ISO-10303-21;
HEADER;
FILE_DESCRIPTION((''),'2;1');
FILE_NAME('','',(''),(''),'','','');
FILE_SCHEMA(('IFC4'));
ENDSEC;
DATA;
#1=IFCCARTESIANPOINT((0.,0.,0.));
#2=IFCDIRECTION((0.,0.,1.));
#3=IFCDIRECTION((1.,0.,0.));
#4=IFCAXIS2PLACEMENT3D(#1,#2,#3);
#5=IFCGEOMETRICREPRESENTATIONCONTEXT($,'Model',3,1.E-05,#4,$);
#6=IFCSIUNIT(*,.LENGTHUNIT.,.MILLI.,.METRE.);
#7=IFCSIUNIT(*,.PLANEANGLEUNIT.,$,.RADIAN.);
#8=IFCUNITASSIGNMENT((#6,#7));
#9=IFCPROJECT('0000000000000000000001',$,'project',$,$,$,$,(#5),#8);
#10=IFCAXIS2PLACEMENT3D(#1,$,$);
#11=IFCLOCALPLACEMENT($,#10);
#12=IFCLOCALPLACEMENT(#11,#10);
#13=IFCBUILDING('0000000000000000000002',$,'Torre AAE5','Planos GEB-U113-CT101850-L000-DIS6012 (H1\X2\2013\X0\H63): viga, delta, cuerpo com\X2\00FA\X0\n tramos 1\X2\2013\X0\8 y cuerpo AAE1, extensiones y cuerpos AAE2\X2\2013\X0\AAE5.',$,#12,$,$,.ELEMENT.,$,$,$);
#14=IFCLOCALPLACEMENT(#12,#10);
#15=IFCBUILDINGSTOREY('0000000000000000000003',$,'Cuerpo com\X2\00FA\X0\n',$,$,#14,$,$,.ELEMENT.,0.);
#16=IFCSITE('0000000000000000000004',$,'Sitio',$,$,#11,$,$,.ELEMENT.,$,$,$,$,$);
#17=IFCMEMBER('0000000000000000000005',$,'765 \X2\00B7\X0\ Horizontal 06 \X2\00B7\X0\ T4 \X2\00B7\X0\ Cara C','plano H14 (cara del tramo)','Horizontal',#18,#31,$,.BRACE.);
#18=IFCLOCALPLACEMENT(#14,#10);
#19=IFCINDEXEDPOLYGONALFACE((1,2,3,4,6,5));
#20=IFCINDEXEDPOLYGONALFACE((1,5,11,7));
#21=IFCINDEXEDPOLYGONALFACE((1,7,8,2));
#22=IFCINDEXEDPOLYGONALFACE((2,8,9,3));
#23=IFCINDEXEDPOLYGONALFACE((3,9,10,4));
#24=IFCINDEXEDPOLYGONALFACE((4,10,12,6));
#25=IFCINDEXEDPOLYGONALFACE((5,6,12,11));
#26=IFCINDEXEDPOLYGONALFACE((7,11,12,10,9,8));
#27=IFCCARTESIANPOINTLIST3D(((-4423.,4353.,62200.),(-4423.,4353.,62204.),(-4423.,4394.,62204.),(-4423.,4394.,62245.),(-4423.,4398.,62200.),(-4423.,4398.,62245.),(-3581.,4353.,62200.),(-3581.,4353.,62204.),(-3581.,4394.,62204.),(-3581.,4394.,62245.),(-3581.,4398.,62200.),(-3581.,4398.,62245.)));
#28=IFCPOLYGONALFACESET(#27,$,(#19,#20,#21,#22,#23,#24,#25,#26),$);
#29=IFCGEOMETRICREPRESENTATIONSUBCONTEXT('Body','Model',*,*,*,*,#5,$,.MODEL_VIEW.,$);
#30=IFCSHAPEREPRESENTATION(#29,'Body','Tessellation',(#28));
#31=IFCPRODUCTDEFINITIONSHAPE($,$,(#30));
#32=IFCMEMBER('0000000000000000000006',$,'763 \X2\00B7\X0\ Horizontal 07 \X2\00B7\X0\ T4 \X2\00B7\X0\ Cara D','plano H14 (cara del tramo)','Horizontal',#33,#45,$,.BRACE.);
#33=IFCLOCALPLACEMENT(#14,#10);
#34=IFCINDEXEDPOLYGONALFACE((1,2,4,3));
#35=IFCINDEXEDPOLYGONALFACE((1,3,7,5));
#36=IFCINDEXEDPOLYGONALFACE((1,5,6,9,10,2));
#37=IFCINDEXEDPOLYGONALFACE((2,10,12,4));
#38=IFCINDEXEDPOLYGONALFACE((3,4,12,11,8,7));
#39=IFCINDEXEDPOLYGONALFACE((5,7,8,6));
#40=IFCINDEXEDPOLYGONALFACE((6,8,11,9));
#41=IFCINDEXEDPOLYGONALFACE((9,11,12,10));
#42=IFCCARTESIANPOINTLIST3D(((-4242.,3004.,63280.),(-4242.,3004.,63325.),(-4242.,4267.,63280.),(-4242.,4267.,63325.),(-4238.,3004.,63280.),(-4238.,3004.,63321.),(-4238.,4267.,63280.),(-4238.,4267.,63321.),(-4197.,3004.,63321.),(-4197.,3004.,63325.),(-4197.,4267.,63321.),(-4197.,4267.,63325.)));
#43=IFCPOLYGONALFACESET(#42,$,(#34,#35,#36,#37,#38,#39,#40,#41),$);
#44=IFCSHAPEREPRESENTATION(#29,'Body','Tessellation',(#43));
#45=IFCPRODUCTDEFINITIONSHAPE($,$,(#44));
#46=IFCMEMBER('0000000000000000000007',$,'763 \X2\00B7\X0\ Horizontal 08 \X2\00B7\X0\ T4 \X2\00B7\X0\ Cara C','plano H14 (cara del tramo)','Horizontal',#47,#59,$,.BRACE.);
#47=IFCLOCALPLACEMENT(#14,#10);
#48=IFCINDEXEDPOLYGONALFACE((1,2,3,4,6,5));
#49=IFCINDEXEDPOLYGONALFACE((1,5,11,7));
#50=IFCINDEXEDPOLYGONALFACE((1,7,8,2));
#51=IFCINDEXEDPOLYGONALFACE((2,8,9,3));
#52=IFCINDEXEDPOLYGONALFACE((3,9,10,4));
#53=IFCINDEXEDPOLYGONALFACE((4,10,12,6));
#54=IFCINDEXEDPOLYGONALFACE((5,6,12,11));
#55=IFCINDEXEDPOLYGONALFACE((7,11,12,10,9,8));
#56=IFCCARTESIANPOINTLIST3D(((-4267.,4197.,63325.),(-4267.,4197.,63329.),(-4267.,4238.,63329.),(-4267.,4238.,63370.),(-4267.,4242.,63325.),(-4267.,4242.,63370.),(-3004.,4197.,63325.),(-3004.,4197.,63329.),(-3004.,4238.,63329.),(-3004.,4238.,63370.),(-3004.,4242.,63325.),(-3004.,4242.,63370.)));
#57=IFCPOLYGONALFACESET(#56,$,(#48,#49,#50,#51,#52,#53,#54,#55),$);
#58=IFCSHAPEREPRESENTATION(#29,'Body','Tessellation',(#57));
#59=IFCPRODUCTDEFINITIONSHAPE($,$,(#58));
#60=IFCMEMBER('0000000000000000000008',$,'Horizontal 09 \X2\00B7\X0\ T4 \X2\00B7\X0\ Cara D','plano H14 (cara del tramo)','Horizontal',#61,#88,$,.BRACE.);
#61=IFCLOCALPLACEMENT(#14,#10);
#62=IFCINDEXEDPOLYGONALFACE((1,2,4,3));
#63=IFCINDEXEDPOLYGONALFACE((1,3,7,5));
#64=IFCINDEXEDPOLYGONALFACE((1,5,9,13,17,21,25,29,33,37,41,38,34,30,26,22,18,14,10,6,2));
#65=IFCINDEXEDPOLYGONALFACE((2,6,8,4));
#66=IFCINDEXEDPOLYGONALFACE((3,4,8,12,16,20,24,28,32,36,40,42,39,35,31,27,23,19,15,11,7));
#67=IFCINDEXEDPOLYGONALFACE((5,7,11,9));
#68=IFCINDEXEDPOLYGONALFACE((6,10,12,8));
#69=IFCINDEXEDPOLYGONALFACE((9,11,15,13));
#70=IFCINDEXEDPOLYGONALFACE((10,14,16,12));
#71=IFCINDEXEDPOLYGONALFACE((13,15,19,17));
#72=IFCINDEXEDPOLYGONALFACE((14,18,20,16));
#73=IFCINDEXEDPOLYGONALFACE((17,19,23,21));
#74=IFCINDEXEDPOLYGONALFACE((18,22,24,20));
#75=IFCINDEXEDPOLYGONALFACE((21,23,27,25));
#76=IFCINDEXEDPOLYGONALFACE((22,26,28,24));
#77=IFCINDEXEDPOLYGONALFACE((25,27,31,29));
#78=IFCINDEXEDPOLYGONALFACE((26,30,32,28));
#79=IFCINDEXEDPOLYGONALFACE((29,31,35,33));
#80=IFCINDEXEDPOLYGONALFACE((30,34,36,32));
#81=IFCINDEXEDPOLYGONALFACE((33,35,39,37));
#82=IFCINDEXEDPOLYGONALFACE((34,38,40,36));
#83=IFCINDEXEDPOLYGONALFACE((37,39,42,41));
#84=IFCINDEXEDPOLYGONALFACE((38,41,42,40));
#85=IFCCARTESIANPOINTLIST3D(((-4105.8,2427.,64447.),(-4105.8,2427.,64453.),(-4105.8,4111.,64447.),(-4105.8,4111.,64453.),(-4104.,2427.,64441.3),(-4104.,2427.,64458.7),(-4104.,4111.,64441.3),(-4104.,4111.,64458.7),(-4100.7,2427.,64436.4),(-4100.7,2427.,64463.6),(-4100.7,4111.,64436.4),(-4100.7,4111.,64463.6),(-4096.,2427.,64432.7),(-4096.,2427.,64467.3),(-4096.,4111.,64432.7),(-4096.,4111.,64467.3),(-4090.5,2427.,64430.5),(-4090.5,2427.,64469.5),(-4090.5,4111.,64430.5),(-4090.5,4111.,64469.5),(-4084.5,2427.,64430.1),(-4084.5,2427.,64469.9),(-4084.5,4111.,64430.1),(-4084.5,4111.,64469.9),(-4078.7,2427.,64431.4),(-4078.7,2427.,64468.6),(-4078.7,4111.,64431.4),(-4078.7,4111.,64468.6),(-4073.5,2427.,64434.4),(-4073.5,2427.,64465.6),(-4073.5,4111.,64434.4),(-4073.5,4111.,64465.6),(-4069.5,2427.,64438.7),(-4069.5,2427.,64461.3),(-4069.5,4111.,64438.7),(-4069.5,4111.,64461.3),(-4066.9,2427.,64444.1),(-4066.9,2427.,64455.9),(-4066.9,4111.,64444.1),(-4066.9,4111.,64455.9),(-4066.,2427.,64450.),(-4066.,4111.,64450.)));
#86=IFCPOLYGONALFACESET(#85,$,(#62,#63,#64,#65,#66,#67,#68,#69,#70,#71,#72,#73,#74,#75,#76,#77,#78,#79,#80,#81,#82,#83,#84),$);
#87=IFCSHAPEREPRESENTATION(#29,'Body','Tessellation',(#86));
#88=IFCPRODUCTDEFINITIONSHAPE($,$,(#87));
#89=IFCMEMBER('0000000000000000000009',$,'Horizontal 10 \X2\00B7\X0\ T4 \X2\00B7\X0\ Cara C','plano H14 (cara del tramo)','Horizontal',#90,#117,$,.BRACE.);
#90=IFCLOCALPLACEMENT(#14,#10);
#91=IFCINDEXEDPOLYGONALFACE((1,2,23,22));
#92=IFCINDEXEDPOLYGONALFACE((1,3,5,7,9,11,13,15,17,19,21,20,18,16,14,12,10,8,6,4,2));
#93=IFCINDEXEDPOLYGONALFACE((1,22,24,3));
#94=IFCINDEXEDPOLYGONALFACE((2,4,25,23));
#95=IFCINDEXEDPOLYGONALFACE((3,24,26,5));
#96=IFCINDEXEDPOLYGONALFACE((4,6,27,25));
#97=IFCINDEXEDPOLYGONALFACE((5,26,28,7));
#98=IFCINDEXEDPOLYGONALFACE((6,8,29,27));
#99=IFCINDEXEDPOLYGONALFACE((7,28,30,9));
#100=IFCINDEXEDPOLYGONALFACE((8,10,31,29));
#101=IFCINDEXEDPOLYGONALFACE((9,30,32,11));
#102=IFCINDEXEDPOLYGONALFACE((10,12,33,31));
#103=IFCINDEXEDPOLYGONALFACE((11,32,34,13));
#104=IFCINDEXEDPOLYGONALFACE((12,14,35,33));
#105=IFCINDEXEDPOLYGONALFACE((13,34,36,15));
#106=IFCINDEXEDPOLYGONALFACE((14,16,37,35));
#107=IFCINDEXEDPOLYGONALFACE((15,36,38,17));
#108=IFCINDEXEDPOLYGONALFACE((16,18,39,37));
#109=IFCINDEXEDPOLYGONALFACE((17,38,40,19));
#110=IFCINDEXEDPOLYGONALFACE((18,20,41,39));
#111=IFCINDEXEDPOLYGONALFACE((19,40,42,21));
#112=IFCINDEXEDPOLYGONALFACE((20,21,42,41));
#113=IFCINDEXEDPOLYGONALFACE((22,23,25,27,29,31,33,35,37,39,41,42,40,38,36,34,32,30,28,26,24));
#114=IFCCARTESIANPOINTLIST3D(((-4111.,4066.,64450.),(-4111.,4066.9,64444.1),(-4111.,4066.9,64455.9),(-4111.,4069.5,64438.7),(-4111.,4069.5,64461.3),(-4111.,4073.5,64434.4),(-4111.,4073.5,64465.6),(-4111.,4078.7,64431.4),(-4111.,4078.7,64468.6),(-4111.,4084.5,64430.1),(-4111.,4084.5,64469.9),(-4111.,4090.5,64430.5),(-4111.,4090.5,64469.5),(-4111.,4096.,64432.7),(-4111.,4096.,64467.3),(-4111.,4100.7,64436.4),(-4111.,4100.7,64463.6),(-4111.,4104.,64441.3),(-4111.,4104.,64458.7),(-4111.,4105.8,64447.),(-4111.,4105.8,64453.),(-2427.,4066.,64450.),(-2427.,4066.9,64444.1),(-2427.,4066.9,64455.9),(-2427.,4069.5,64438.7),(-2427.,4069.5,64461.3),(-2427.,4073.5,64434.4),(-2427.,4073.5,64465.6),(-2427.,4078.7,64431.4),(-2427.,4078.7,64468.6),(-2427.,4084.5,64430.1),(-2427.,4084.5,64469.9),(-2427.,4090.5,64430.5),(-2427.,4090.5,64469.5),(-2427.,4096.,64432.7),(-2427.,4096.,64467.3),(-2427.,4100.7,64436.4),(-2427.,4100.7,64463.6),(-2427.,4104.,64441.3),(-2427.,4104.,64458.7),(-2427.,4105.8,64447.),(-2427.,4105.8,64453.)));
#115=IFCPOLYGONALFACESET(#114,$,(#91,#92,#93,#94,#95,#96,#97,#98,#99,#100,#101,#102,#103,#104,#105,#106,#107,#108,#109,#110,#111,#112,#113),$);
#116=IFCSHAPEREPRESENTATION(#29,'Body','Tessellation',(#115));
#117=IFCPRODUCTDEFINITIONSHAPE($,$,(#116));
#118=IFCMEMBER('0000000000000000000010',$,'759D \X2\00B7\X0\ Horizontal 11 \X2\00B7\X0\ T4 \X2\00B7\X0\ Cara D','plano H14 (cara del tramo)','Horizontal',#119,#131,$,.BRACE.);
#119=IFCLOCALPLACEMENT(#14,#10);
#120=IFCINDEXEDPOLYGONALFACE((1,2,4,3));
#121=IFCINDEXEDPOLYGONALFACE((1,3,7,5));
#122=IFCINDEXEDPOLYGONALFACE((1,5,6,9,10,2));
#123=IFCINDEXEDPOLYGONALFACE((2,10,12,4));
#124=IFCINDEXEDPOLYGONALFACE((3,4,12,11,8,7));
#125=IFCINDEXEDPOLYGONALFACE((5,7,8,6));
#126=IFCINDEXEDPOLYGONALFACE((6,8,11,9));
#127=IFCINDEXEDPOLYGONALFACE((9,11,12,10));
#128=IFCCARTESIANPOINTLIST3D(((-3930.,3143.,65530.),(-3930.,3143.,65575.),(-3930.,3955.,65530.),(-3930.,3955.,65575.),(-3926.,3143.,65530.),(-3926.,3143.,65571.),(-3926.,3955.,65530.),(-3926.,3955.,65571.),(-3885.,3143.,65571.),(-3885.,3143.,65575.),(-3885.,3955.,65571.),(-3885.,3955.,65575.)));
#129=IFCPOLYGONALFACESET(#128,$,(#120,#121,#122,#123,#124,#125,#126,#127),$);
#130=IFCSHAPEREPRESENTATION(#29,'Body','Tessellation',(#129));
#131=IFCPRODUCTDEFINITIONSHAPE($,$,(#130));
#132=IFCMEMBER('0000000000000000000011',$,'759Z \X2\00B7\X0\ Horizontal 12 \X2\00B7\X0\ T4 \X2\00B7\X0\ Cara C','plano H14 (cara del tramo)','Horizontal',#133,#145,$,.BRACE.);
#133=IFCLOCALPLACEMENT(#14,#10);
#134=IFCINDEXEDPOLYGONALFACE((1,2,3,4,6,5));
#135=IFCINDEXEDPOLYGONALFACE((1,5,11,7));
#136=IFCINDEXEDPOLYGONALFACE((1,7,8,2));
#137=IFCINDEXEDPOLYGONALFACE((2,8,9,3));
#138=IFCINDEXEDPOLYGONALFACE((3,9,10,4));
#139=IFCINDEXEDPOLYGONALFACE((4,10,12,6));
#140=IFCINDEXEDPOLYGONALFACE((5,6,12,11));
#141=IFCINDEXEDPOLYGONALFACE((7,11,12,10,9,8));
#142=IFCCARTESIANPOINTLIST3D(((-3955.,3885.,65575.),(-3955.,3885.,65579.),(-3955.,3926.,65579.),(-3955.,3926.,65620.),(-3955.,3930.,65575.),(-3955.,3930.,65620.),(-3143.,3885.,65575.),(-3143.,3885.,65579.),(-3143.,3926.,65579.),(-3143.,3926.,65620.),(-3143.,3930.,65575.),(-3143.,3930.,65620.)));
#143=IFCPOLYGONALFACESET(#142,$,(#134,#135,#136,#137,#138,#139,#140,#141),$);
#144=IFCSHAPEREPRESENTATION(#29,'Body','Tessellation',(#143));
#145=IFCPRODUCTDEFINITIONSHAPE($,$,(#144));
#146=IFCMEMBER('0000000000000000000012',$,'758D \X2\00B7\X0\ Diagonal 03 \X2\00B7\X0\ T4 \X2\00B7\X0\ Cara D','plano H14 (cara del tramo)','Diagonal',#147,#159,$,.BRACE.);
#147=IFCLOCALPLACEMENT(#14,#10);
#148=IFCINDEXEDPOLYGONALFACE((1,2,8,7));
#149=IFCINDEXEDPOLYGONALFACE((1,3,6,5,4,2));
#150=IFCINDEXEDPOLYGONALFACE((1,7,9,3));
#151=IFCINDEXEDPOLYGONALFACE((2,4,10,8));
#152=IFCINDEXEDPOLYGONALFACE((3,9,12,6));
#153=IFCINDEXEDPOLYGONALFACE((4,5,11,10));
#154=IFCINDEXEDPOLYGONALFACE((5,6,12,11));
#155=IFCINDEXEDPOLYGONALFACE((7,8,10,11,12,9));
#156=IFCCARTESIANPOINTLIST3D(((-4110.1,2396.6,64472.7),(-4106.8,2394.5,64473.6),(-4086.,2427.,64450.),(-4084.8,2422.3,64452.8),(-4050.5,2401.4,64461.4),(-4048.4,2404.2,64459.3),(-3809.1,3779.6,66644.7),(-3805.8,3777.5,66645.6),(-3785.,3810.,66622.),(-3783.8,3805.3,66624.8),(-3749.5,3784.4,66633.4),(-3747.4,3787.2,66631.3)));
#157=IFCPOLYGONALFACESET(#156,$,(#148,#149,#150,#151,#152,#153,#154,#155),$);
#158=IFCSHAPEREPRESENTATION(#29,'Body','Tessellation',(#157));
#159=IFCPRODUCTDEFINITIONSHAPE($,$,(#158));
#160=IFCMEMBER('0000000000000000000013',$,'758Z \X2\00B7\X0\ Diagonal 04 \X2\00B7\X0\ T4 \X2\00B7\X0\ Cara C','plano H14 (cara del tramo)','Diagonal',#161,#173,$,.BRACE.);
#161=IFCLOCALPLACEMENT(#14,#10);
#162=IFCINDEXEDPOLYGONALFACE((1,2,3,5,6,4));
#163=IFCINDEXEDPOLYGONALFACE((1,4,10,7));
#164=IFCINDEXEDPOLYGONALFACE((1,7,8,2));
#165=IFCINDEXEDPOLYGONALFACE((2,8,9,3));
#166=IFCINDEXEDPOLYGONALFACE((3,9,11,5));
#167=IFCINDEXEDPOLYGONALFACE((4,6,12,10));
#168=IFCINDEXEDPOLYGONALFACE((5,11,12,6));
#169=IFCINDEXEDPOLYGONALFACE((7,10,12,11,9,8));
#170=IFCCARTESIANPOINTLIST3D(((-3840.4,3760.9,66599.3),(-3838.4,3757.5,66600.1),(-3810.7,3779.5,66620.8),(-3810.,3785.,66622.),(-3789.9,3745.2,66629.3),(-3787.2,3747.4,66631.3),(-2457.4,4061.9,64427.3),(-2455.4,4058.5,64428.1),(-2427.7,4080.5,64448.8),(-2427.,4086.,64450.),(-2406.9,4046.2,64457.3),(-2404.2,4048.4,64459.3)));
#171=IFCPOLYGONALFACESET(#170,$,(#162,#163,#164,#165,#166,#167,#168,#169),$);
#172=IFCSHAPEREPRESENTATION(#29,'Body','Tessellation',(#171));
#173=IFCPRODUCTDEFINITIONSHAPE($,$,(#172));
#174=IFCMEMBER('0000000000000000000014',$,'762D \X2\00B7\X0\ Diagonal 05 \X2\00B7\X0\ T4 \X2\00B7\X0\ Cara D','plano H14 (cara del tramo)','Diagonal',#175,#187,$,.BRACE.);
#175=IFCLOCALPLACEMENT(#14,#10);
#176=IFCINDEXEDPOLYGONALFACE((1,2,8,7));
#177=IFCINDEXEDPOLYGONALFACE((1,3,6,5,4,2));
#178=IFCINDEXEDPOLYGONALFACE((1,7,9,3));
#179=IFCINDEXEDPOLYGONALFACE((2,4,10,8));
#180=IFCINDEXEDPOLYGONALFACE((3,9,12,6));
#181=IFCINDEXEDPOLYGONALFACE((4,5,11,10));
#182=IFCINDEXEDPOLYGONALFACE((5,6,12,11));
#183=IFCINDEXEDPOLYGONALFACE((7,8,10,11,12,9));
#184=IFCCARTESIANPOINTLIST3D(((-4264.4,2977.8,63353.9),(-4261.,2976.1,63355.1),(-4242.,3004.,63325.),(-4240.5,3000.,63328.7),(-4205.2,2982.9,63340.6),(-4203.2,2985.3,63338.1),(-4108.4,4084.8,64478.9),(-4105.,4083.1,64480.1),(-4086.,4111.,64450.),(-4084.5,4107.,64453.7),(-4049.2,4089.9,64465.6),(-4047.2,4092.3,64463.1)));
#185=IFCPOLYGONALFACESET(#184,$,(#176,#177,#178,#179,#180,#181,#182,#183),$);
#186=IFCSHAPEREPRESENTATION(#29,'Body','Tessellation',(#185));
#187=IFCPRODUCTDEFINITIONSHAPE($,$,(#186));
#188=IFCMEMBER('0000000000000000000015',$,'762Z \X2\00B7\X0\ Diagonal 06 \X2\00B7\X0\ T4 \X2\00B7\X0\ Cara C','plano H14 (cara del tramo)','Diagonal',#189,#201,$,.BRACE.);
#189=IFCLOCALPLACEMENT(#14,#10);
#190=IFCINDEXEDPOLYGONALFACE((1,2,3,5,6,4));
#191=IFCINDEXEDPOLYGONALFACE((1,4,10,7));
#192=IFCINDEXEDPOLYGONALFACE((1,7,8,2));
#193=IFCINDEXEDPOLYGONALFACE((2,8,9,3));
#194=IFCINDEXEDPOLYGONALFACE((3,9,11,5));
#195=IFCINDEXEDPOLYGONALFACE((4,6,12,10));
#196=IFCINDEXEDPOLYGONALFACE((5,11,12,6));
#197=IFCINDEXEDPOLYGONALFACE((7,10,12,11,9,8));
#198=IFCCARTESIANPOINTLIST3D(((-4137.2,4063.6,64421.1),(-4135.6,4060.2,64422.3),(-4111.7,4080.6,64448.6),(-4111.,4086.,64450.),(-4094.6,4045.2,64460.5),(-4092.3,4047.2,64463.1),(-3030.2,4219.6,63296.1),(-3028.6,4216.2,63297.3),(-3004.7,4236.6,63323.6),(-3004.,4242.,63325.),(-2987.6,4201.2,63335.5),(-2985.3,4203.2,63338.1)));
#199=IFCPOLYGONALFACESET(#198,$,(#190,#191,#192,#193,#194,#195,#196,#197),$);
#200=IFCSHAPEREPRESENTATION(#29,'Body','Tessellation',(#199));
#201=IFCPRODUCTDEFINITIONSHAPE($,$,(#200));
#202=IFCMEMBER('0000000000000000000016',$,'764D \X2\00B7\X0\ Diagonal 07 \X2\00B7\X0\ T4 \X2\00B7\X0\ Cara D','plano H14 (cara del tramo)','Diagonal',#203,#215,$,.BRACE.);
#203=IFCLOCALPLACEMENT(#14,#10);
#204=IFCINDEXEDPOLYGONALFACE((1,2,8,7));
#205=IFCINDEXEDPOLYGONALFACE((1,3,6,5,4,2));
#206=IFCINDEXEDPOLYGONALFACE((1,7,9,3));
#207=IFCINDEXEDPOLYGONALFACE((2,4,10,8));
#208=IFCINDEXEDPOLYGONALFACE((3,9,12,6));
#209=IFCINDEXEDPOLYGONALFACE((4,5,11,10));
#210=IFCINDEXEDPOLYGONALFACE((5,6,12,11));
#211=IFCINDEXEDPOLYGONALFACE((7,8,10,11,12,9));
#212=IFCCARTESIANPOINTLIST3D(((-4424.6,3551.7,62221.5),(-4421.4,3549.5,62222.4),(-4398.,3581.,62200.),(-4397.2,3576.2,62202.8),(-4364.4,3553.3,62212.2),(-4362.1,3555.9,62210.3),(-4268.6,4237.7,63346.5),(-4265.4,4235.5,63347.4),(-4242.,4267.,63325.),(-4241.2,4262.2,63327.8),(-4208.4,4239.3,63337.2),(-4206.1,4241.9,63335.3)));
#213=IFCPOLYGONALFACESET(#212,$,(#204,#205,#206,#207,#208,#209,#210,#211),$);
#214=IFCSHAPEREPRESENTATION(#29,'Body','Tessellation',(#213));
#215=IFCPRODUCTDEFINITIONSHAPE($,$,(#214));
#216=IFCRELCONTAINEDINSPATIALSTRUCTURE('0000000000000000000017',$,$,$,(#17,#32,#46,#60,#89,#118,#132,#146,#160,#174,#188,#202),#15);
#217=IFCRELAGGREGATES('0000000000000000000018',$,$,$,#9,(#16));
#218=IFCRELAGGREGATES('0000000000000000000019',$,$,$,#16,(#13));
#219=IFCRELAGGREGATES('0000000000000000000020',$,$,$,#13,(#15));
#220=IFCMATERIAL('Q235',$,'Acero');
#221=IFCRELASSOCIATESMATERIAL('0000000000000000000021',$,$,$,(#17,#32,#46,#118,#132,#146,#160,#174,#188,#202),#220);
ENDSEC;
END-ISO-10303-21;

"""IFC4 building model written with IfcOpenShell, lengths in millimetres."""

from ifc_helpers import new_model, si_unit, frame, frame_2d, origin, origin_with_axes, place, context, subcontext, project, spatial, circle, l_section, extrude, material, element, save


model = new_model("IFC4")

# Units and contexts
model_context = context("Model", 3, precision=1e-05, world=origin_with_axes())
body_context = subcontext(model_context, "Body", "Model", "MODEL_VIEW")
ifc_project = project(units=[si_unit("LENGTHUNIT", "METRE", prefix="MILLI"), si_unit("PLANEANGLEUNIT", "RADIAN")], contexts=[model_context])

# Site, building, storey
site_placement = place(None, origin())
site = spatial("IfcSite", under=ifc_project, at=site_placement, Name="Sitio", CompositionType="ELEMENT")
building_placement = place(site_placement, origin())
building = spatial("IfcBuilding", under=site, at=building_placement, Name="Torre AAE5", Description="Planos GEB-U113-CT101850-L000-DIS6012 (H1–H63): viga, delta, cuerpo común tramos 1–8 y cuerpo AAE1, extensiones y cuerpos AAE2–AAE5.", CompositionType="ELEMENT")
storey_placement = place(building_placement, origin())
storey = spatial("IfcBuildingStorey", under=building, at=storey_placement, Name="Cuerpo común", CompositionType="ELEMENT", Elevation=0.0)

# Members
ifc_material_1 = material(Name="Q235", Category="Acero")
member_1_placement = place(storey_placement, frame((-3581.0, 4398.0, 62200.0), z_axis=(-1.0, 0.0, 0.0), x_axis=(0.0, -1.0, 0.0)))
element("IfcMember", 1, at=member_1_placement, inside=storey, material=ifc_material_1, Name="765 · Horizontal 06 · T4 · Cara C", Description="plano H14 (cara del tramo)", ObjectType="Horizontal", PredefinedType="BRACE", context=body_context, shape_type="SweptSolid", body=[
    extrude(l_section(Depth=45.0, Width=45.0, Thickness=4.0, at=frame_2d((22.5, 22.5))), None, (0.0, 0.0, 1.0), 842.0),
])
for number, where, z_axis, x_axis, name in (
    (2, (-4242.0, 3004.0, 63325.0), (0.0, 1.0, 0.0), (1.0, 0.0, 0.0), "763 · Horizontal 07 · T4 · Cara D"),
    (3, (-3004.0, 4242.0, 63325.0), (-1.0, 0.0, 0.0), (0.0, -1.0, 0.0), "763 · Horizontal 08 · T4 · Cara C"),
):
    element("IfcMember", number, at=place(storey_placement, frame(where, z_axis=z_axis, x_axis=x_axis)), inside=storey, material=ifc_material_1, Name=name, Description="plano H14 (cara del tramo)", ObjectType="Horizontal", PredefinedType="BRACE", context=body_context, shape_type="SweptSolid", body=[
        extrude(l_section(Depth=45.0, Width=45.0, Thickness=4.0, at=frame_2d((22.5, 22.5))), None, (0.0, 0.0, 1.0), 1263.0),
    ])
for number, where, z_axis, x_axis, name in (
    (4, (-4086.0, 2427.0, 64450.0), (0.0, 1.0, 0.0), (1.0, 0.0, 0.0), "Horizontal 09 · T4 · Cara D"),
    (5, (-2427.0, 4086.0, 64450.0), (-1.0, 0.0, 0.0), (0.0, -1.0, 0.0), "Horizontal 10 · T4 · Cara C"),
):
    element("IfcMember", number, at=place(storey_placement, frame(where, z_axis=z_axis, x_axis=x_axis)), inside=storey, Name=name, Description="plano H14 (cara del tramo)", ObjectType="Horizontal", PredefinedType="BRACE", context=body_context, shape_type="SweptSolid", body=[
        extrude(circle(Radius=20.0), None, (0.0, 0.0, 1.0), 1684.0),
    ])
for number, where, z_axis, x_axis, name in (
    (6, (-3930.0, 3143.0, 65575.0), (0.0, 1.0, 0.0), (1.0, 0.0, 0.0), "759D · Horizontal 11 · T4 · Cara D"),
    (7, (-3143.0, 3930.0, 65575.0), (-1.0, 0.0, 0.0), (0.0, -1.0, 0.0), "759Z · Horizontal 12 · T4 · Cara C"),
):
    element("IfcMember", number, at=place(storey_placement, frame(where, z_axis=z_axis, x_axis=x_axis)), inside=storey, material=ifc_material_1, Name=name, Description="plano H14 (cara del tramo)", ObjectType="Horizontal", PredefinedType="BRACE", context=body_context, shape_type="SweptSolid", body=[
        extrude(l_section(Depth=45.0, Width=45.0, Thickness=4.0, at=frame_2d((22.5, 22.5))), None, (0.0, 0.0, 1.0), 812.0),
    ])
for number, where, z_axis, x_axis, name in (
    (8, (-3785.0, 3810.0, 66622.0), (-0.116106, -0.533469, -0.837813), (0.836171, -0.507736, 0.207418), "758D · Diagonal 03 · T4 · Cara D"),
    (9, (-3810.0, 3785.0, 66622.0), (0.533469, 0.116106, -0.837813), (0.507736, -0.836171, 0.207418), "758Z · Diagonal 04 · T4 · Cara C"),
):
    element("IfcMember", number, at=place(storey_placement, frame(where, z_axis=z_axis, x_axis=x_axis)), inside=storey, material=ifc_material_1, Name=name, Description="plano H14 (cara del tramo)", ObjectType="Diagonal", PredefinedType="BRACE", context=body_context, shape_type="SweptSolid", body=[
        extrude(l_section(Depth=45.0, Width=45.0, Thickness=4.0, at=frame_2d((22.5, 22.5))), None, (0.0, 0.0, 1.0), 2592.5),
    ])
for number, where, z_axis, x_axis, name in (
    (10, (-4086.0, 4111.0, 64450.0), (-0.09836, -0.69798, -0.70933), (0.861689, -0.416299, 0.290151), "762D · Diagonal 05 · T4 · Cara D"),
    (11, (-4111.0, 4086.0, 64450.0), (0.69798, 0.09836, -0.70933), (0.416299, -0.861689, 0.290151), "762Z · Diagonal 06 · T4 · Cara C"),
):
    element("IfcMember", number, at=place(storey_placement, frame(where, z_axis=z_axis, x_axis=x_axis)), inside=storey, material=ifc_material_1, Name=name, Description="plano H14 (cara del tramo)", ObjectType="Diagonal", PredefinedType="BRACE", context=body_context, shape_type="SweptSolid", body=[
        extrude(l_section(Depth=45.0, Width=45.0, Thickness=4.0, at=frame_2d((22.5, 22.5))), None, (0.0, 0.0, 1.0), 1586.0),
    ])
for number, where, z_axis, x_axis, name in (
    (12, (-4242.0, 4267.0, 63325.0), (-0.117571, -0.51701, -0.847867), (0.798444, -0.556878, 0.228854), "764D · Diagonal 07 · T4 · Cara D"),
):
    element("IfcMember", number, at=place(storey_placement, frame(where, z_axis=z_axis, x_axis=x_axis)), inside=storey, material=ifc_material_1, Name=name, Description="plano H14 (cara del tramo)", ObjectType="Diagonal", PredefinedType="BRACE", context=body_context, shape_type="SweptSolid", body=[
        extrude(l_section(Depth=45.0, Width=45.0, Thickness=4.0, at=frame_2d((22.5, 22.5))), None, (0.0, 0.0, 1.0), 1326.9),
    ])

save(model, "model.ifc")
